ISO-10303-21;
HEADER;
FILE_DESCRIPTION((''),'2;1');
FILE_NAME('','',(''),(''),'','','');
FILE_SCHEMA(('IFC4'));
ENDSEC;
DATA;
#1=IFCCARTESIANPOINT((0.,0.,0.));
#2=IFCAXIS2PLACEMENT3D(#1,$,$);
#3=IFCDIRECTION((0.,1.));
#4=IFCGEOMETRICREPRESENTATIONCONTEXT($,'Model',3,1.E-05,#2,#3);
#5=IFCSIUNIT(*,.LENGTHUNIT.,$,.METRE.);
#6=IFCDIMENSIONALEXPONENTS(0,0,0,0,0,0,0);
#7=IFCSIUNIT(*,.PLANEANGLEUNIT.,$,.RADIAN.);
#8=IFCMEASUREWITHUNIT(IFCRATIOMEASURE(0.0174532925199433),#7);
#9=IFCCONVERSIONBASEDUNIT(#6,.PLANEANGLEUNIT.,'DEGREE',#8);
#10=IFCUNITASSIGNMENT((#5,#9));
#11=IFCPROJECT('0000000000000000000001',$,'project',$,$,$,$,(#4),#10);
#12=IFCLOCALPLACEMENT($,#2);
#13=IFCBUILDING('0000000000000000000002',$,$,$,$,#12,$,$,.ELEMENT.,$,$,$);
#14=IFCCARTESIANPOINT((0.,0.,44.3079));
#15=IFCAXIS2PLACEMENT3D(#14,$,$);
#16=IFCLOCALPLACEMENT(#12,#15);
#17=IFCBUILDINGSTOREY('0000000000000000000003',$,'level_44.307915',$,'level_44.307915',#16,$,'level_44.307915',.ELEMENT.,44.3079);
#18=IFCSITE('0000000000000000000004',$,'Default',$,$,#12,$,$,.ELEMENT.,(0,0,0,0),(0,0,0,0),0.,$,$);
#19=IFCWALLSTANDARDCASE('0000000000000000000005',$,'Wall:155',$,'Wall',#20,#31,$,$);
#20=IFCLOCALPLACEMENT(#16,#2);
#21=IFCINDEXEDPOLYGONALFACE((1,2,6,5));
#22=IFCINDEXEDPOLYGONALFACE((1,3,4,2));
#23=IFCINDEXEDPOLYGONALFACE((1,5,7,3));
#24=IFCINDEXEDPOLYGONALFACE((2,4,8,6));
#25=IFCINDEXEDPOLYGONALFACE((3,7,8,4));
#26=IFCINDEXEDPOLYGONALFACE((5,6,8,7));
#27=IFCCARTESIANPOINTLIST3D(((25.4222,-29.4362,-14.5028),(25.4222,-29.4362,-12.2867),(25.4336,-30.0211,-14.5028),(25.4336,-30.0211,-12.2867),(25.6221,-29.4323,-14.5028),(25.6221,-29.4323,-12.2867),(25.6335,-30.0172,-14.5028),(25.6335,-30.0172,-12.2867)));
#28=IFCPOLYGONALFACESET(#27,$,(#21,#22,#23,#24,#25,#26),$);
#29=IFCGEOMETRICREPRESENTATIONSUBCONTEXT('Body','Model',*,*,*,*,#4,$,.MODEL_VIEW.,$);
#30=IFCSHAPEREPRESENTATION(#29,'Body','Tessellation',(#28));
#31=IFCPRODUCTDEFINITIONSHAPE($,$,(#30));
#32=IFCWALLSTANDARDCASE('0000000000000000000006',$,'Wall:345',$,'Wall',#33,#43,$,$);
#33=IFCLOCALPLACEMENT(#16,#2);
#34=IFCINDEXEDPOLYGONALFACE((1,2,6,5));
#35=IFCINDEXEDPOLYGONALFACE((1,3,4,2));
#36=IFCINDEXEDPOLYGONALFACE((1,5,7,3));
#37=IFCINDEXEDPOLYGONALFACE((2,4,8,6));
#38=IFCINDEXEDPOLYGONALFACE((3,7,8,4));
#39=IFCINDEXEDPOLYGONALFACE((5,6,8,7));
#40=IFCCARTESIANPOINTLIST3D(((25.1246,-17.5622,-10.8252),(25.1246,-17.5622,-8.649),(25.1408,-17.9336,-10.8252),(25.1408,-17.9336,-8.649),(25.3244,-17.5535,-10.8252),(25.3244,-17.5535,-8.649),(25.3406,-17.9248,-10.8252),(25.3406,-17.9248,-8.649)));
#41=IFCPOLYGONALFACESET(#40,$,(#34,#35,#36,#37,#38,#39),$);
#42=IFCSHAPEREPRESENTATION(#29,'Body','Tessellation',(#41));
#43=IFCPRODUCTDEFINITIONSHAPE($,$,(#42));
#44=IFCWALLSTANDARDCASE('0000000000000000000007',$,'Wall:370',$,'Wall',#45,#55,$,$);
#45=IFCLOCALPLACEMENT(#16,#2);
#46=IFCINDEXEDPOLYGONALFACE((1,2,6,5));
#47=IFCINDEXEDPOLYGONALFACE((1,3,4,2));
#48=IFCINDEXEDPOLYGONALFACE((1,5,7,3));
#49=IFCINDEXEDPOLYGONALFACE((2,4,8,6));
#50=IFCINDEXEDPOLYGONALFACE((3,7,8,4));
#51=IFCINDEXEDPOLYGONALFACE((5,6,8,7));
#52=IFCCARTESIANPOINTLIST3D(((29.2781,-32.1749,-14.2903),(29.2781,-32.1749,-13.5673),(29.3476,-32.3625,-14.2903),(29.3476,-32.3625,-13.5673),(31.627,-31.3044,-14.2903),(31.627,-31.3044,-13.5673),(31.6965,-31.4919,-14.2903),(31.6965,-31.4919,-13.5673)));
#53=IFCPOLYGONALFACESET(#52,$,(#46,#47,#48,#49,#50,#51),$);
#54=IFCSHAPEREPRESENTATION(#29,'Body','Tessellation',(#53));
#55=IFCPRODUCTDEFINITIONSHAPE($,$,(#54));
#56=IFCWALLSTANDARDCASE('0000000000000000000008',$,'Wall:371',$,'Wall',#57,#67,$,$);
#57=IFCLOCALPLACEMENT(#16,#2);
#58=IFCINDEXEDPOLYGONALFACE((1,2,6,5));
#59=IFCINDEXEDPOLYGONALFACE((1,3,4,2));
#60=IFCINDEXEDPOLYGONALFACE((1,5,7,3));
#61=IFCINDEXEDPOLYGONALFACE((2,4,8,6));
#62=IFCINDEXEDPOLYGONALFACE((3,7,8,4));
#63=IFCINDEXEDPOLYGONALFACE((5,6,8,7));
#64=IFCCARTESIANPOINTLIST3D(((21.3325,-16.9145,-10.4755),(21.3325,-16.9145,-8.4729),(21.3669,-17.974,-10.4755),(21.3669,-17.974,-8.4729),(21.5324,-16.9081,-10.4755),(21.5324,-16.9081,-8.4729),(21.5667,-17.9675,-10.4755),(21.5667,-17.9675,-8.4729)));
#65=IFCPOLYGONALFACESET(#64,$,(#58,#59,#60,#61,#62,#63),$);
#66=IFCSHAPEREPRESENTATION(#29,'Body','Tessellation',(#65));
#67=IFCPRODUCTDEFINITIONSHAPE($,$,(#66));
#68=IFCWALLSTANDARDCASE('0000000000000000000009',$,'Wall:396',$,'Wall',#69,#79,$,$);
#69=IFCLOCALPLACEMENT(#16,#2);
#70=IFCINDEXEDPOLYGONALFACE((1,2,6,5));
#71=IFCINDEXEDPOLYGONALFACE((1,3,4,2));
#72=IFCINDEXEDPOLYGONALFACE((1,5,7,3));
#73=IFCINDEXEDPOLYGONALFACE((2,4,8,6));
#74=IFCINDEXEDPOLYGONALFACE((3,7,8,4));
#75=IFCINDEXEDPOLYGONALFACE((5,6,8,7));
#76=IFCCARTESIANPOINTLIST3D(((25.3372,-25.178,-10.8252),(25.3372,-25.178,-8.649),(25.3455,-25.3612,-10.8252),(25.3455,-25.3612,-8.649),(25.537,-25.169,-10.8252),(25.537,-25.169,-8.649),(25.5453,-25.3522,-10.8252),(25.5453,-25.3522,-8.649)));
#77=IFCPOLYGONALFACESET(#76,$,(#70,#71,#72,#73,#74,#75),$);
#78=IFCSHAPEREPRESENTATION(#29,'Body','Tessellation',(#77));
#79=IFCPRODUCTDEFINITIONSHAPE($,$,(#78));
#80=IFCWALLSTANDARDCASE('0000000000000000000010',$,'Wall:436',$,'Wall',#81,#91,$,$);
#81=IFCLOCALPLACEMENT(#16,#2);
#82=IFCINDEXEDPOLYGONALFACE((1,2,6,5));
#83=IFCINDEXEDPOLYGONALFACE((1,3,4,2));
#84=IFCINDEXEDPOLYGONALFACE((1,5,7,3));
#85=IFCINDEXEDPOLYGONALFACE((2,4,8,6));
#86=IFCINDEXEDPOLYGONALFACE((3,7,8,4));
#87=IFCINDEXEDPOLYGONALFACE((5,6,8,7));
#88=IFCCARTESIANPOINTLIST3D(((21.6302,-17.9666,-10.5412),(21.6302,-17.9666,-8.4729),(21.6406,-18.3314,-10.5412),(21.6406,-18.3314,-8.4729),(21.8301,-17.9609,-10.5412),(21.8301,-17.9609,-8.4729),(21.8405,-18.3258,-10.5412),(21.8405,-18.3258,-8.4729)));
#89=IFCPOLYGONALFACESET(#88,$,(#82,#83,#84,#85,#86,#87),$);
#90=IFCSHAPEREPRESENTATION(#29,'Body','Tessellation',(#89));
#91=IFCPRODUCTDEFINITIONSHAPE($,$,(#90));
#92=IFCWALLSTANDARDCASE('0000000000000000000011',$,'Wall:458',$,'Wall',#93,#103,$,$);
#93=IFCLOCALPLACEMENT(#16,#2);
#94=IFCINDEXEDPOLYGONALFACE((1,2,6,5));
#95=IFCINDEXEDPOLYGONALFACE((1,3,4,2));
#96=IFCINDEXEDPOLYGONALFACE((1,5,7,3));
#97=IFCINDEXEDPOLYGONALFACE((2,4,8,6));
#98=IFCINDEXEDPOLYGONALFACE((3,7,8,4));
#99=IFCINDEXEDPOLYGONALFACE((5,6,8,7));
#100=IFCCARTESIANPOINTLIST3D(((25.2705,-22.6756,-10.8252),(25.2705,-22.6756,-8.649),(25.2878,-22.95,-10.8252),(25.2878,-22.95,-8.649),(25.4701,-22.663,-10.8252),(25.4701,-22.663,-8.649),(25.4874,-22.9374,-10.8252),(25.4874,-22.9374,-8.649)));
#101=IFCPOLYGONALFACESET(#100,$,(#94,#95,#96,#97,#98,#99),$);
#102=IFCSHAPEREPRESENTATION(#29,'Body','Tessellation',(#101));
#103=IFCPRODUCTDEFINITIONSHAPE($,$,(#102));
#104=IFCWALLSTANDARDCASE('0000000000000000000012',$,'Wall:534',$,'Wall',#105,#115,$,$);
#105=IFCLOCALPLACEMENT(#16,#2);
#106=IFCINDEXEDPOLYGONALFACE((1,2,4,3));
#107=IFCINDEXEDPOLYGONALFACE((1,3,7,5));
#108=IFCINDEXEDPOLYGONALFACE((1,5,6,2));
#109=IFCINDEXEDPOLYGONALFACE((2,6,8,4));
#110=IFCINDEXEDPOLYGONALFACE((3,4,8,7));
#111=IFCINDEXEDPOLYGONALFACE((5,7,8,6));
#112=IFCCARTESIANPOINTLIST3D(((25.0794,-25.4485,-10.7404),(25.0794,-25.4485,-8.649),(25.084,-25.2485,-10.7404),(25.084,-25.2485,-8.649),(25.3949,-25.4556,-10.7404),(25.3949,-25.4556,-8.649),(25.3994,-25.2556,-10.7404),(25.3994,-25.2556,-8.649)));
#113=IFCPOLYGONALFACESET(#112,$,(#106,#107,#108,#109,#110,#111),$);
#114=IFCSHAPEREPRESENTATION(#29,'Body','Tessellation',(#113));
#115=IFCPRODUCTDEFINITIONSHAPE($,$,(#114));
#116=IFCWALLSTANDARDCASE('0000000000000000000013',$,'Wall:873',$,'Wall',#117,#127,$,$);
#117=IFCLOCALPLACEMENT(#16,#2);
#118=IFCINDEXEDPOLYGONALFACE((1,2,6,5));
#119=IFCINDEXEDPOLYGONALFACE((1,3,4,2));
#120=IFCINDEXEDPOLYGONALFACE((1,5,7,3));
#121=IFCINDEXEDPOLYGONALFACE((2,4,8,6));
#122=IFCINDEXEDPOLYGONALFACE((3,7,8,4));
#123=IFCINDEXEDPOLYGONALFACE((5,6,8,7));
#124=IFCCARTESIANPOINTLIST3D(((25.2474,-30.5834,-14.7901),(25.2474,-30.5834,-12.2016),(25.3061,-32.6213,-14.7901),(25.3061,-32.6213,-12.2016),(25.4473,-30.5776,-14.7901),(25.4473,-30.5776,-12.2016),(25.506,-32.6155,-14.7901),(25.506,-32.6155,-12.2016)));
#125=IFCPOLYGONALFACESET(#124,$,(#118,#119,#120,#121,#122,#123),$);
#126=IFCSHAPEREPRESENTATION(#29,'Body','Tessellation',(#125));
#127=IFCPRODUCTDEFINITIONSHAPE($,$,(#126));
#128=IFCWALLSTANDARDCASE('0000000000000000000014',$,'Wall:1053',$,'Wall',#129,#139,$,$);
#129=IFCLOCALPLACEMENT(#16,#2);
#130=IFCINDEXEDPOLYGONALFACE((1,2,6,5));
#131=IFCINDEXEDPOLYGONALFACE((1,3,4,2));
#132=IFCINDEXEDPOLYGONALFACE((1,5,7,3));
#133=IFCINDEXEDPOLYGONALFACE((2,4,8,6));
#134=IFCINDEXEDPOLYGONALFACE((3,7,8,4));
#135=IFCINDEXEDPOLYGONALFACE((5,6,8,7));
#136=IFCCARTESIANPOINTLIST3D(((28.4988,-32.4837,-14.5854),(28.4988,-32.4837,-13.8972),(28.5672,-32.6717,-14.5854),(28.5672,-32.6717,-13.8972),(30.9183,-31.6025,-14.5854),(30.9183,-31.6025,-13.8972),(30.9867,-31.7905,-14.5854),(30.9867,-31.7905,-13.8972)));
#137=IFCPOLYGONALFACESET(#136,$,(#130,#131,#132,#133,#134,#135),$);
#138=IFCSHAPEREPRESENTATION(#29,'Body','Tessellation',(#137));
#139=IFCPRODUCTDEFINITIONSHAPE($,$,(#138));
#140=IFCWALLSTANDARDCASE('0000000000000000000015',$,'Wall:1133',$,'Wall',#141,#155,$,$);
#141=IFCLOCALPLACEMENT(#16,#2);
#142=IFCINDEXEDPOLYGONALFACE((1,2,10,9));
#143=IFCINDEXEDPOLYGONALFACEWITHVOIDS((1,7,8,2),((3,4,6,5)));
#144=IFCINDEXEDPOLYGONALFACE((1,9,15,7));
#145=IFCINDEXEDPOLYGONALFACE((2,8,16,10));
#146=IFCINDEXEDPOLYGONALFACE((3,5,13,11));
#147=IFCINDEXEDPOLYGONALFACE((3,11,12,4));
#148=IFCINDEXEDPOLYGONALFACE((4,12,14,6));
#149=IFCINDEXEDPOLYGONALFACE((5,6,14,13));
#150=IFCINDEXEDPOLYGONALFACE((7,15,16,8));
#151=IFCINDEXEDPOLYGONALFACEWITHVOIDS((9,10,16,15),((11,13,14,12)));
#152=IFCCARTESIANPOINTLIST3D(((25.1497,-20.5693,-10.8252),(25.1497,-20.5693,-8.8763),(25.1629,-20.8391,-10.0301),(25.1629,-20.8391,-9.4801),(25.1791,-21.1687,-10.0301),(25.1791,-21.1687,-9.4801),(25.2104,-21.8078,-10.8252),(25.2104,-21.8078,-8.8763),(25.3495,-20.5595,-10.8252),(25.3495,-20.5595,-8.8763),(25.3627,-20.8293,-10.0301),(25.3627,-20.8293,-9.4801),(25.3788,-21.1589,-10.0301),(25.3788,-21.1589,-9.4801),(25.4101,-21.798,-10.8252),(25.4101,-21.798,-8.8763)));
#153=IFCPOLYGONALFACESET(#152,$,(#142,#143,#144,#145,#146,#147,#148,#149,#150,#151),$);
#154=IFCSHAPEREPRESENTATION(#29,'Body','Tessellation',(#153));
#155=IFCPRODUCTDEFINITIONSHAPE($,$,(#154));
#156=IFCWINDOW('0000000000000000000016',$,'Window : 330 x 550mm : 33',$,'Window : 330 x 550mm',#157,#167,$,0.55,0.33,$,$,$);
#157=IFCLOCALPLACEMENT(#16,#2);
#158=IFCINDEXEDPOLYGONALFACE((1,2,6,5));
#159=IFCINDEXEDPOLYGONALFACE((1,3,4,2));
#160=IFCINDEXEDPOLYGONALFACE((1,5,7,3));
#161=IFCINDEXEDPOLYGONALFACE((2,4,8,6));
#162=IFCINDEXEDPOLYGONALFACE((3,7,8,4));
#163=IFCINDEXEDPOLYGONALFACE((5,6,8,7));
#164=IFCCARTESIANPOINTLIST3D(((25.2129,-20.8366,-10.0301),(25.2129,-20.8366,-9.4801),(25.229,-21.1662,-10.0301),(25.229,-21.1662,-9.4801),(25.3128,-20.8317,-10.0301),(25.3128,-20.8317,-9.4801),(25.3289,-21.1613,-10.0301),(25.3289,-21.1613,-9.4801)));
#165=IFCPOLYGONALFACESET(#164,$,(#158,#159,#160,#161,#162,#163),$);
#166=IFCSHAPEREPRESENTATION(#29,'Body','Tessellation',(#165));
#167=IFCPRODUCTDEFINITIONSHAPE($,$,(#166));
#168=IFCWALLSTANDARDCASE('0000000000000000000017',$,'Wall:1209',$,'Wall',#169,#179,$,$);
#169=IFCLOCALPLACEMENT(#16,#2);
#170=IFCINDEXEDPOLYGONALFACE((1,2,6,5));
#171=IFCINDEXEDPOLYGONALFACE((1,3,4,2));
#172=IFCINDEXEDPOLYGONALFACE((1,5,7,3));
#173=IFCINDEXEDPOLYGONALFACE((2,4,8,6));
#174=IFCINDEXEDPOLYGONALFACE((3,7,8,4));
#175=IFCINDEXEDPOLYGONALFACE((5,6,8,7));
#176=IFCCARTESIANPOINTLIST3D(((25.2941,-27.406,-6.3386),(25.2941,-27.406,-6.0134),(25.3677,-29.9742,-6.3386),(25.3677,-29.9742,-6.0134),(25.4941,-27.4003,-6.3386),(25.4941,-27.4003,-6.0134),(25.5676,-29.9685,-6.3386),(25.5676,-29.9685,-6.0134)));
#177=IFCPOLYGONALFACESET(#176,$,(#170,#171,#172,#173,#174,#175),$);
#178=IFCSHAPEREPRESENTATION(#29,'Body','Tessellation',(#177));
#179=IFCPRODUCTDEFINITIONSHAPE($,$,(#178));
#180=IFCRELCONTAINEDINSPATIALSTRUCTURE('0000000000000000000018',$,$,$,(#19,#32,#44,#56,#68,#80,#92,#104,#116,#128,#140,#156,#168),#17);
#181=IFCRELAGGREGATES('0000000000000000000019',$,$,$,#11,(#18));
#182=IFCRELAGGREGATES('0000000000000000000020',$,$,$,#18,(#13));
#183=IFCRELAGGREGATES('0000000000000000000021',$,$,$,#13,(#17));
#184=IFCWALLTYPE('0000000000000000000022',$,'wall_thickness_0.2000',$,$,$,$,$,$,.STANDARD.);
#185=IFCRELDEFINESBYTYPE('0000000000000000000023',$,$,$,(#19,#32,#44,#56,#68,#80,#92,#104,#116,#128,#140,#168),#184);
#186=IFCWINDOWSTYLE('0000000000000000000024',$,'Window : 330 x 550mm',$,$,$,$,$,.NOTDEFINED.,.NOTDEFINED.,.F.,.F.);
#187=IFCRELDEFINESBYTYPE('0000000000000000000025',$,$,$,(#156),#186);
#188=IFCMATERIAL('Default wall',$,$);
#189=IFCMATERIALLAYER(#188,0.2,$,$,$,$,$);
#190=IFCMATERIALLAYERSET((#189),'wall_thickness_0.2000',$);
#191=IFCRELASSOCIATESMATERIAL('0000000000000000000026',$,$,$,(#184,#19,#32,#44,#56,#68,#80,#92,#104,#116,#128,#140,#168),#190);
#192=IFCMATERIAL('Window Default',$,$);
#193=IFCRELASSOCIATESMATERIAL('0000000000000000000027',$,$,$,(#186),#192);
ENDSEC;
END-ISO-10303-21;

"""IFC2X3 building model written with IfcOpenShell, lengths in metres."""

from ifc_helpers import new_model, entity, si_unit, converted_unit, direction, frame, frame_2d, origin, origin_2d_with_axis, place, context, subcontext, project, spatial, polyline, rectangle, outline, extrude, source, transform, mapped, material, layer, layer_set, layer_usage, type_object, type_shapes, element, fill, save


model = new_model("IFC2X3")

# Units and contexts
model_context = context("Model", 3, precision=1e-05, world=origin(), true_north=direction((0.0, 1.0)))
body_context = subcontext(model_context, "Body", "Model", "MODEL_VIEW")
ifc_project = project(units=[si_unit("LENGTHUNIT", "METRE"), converted_unit("PLANEANGLEUNIT", "DEGREE", entity("IfcRatioMeasure", 0.0174532925199433), si_unit("PLANEANGLEUNIT", "RADIAN"), dimensions=[0, 0, 0, 0, 0, 0, 0])], contexts=[model_context])

# Site, building, storey
placement_1 = place(None, origin())
site = spatial("IfcSite", under=ifc_project, at=placement_1, Name="Default", CompositionType="ELEMENT", RefLatitude=(0, 0, 0, 0), RefLongitude=(0, 0, 0, 0), RefElevation=0.0)
building = spatial("IfcBuilding", under=site, at=placement_1, CompositionType="ELEMENT")
storey_placement = place(placement_1, frame((0.0, 0.0, 44.3079)))
storey = spatial("IfcBuildingStorey", under=building, at=storey_placement, Name="level_44.307915", ObjectType="level_44.307915", LongName="level_44.307915", CompositionType="ELEMENT", Elevation=44.3079)

# Walls
ifc_material_1 = material(Name="Default wall")
ifc_layer = layer(ifc_material_1, 0.2)
ifc_layer_set = layer_set([ifc_layer], Name="wall_thickness_0.2000")
ifc_layer_usage = layer_usage(ifc_layer_set, "AXIS2", "POSITIVE", -0.1)
wall_type = type_object("IfcWallType", Name="wall_thickness_0.2000", PredefinedType="STANDARD", material=ifc_layer_set)
placement_2 = place(placement_1, frame((0.0, 0.0, 29.8051)))
wall_1_placement = place(placement_2, frame((25.5335, -30.0191, 0.0), z_axis=(0.0, 0.0, 1.0), x_axis=(-0.019491, 0.99981, 0.0)))
element("IfcWallStandardCase", 1, at=wall_1_placement, inside=storey, type_object=wall_type, material=ifc_layer_usage, Name="Wall:155", ObjectType="Wall", context=body_context, shape_type="SweptSolid", body=[
    extrude(outline(polyline([(0.585, -0.1), (0.585, 0.1), (0.0, 0.1), (0.0, -0.1), (0.585, -0.1)])), origin(), (0.0, 0.0, 1.0), 2.2162),
])
placement_3 = place(placement_1, frame((0.0, 0.0, 33.4827)))
wall_2_placement = place(placement_3, frame((25.2245, -17.5578, 0.0), z_axis=(0.0, 0.0, 1.0), x_axis=(0.04375, -0.999043, 0.0)))
element("IfcWallStandardCase", 2, at=wall_2_placement, inside=storey, type_object=wall_type, material=ifc_layer_usage, Name="Wall:345", ObjectType="Wall", context=body_context, shape_type="SweptSolid", body=[
    extrude(outline(polyline([(0.3717, -0.1), (0.3717, 0.1), (0.0, 0.1), (0.0, -0.1), (0.3717, -0.1)])), origin(), (0.0, 0.0, 1.0), 2.1761),
])
placement_4 = place(placement_1, frame((0.0, 0.0, 30.0176)))
wall_3_placement = place(placement_4, frame((29.3128, -32.2687, 0.0), z_axis=(0.0, 0.0, 1.0), x_axis=(0.937674, 0.347517, 0.0)))
element("IfcWallStandardCase", 3, at=wall_3_placement, inside=storey, type_object=wall_type, material=ifc_layer_usage, Name="Wall:370", ObjectType="Wall", context=body_context, shape_type="SweptSolid", body=[
    extrude(outline(polyline([(2.505, -0.1), (2.505, 0.1), (0.0, 0.1), (0.0, -0.1), (2.505, -0.1)])), origin(), (0.0, 0.0, 1.0), 0.723),
])
placement_5 = place(placement_1, frame((0.0, 0.0, 33.8324)))
wall_4_placement = place(placement_5, frame((21.4668, -17.9707, 0.0), z_axis=(0.0, 0.0, 1.0), x_axis=(-0.03243, 0.999474, 0.0)))
element("IfcWallStandardCase", 4, at=wall_4_placement, inside=storey, type_object=wall_type, material=ifc_layer_usage, Name="Wall:371", ObjectType="Wall", context=body_context, shape_type="SweptSolid", body=[
    extrude(outline(polyline([(1.06, -0.1), (1.06, 0.1), (0.0, 0.1), (0.0, -0.1), (1.06, -0.1)])), origin(), (0.0, 0.0, 1.0), 2.0025),
])
placement_6 = place(placement_1, frame((0.0, 0.0, 33.4827)))
wall_5_placement = place(placement_6, frame((25.4454, -25.3567, 0.0), z_axis=(0.0, 0.0, 1.0), x_axis=(-0.04528, 0.998974, 0.0)))
element("IfcWallStandardCase", 5, at=wall_5_placement, inside=storey, type_object=wall_type, material=ifc_layer_usage, Name="Wall:396", ObjectType="Wall", context=body_context, shape_type="SweptSolid", body=[
    extrude(outline(polyline([(0.1834, -0.1), (0.1834, 0.1), (0.0, 0.1), (0.0, -0.1), (0.1834, -0.1)])), origin(), (0.0, 0.0, 1.0), 2.1761),
])
placement_7 = place(placement_1, frame((0.0, 0.0, 33.7667)))
wall_6_placement = place(placement_7, frame((21.7302, -17.9637, 0.0), z_axis=(0.0, 0.0, 1.0), x_axis=(0.028328, -0.999599, 0.0)))
element("IfcWallStandardCase", 6, at=wall_6_placement, inside=storey, type_object=wall_type, material=ifc_layer_usage, Name="Wall:436", ObjectType="Wall", context=body_context, shape_type="SweptSolid", body=[
    extrude(outline(polyline([(0.365, -0.1), (0.365, 0.1), (0.0, 0.1), (0.0, -0.1), (0.365, -0.1)])), origin(), (0.0, 0.0, 1.0), 2.0683),
])
placement_8 = place(placement_1, frame((0.0, 0.0, 33.4827)))
wall_7_placement = place(placement_8, frame((25.3703, -22.6693, 0.0), z_axis=(0.0, 0.0, 1.0), x_axis=(0.062929, -0.998018, 0.0)))
element("IfcWallStandardCase", 7, at=wall_7_placement, inside=storey, type_object=wall_type, material=ifc_layer_usage, Name="Wall:458", ObjectType="Wall", context=body_context, shape_type="SweptSolid", body=[
    extrude(outline(polyline([(0.275, -0.1), (0.275, 0.1), (0.0, 0.1), (0.0, -0.1), (0.275, -0.1)])), origin(), (0.0, 0.0, 1.0), 2.1761),
])
placement_9 = place(placement_1, frame((0.0, 0.0, 33.5675)))
wall_8_placement = place(placement_9, frame((25.3972, -25.3556, 0.0), z_axis=(0.0, 0.0, 1.0), x_axis=(-0.999744, 0.022626, 0.0)))
element("IfcWallStandardCase", 8, at=wall_8_placement, inside=storey, type_object=wall_type, material=ifc_layer_usage, Name="Wall:534", ObjectType="Wall", context=body_context, shape_type="SweptSolid", body=[
    extrude(outline(polyline([(0.3155, -0.1), (0.3155, 0.1), (0.0, 0.1), (0.0, -0.1), (0.3155, -0.1)])), origin(), (0.0, 0.0, 1.0), 2.0914),
])
placement_10 = place(placement_1, frame((0.0, 0.0, 29.5178)))
wall_9_placement = place(placement_10, frame((25.3474, -30.5805, 0.0), z_axis=(0.0, 0.0, 1.0), x_axis=(0.028788, -0.999586, 0.0)))
element("IfcWallStandardCase", 9, at=wall_9_placement, inside=storey, type_object=wall_type, material=ifc_layer_usage, Name="Wall:873", ObjectType="Wall", context=body_context, shape_type="SweptSolid", body=[
    extrude(outline(polyline([(2.0387, -0.1), (2.0387, 0.1), (0.0, 0.1), (0.0, -0.1), (2.0387, -0.1)])), origin(), (0.0, 0.0, 1.0), 2.5885),
])
placement_11 = place(placement_1, frame((0.0, 0.0, 29.7225)))
wall_10_placement = place(placement_11, frame((28.533, -32.5777, 0.0), z_axis=(0.0, 0.0, 1.0), x_axis=(0.93962, 0.34222, 0.0)))
element("IfcWallStandardCase", 10, at=wall_10_placement, inside=storey, type_object=wall_type, material=ifc_layer_usage, Name="Wall:1053", ObjectType="Wall", context=body_context, shape_type="SweptSolid", body=[
    extrude(outline(polyline([(2.575, -0.1), (2.575, 0.1), (0.0, 0.1), (0.0, -0.1), (2.575, -0.1)])), origin(), (0.0, 0.0, 1.0), 0.6882),
])

# Wall, opening, window
placement_12 = place(placement_1, frame((0.0, 0.0, 33.4827)))
wall_11_placement = place(placement_12, frame((25.3102, -21.8029, 0.0), z_axis=(0.0, 0.0, 1.0), x_axis=(-0.048908, 0.998803, 0.0)))
wall_11 = element("IfcWallStandardCase", 11, at=wall_11_placement, inside=storey, type_object=wall_type, material=ifc_layer_usage, Name="Wall:1133", ObjectType="Wall", context=body_context, shape_type="SweptSolid", body=[
    extrude(outline(polyline([(1.24, -0.1), (1.24, 0.1), (0.0, 0.1), (0.0, -0.1), (1.24, -0.1)])), origin(), (0.0, 0.0, 1.0), 1.9489),
])
opening_1_placement = place(wall_11_placement, frame((0.6399, -0.1, 0.7951)))
opening_1 = element("IfcOpeningElement", 12, at=opening_1_placement, cuts=wall_11, ObjectType="Opening", context=body_context, shape_type="SweptSolid", body=[
    extrude(rectangle(XDim=0.33, YDim=0.55, at=frame_2d((0.275, 0.165), x_axis=(0.0, 1.0))), frame((0.0, 0.0, 0.0), z_axis=(0.0, 1.0, 0.0), x_axis=(0.0, 0.0, 1.0)), (0.0, 0.0, 1.0), 0.2),
])
ifc_material_2 = material(Name="Window Default")
window_style_1 = type_object("IfcWindowStyle", Name="Window : 330 x 550mm", ConstructionType="NOTDEFINED", OperationType="NOTDEFINED", ParameterTakesPrecedence=False, Sizeable=False, material=ifc_material_2)
shared_shape_1 = source(origin(), body_context, "Body", "SweptSolid", [
    extrude(rectangle(XDim=0.1, YDim=0.33, at=origin_2d_with_axis()), frame((0.165, 0.1, 0.0), z_axis=(0.0, 0.0, 1.0), x_axis=(0.0, 1.0, 0.0)), (0.0, 0.0, 1.0), 0.55),
])
type_shapes(window_style_1, [shared_shape_1])
window_1_placement = place(opening_1_placement, origin())
window_1 = element("IfcWindow", 13, at=window_1_placement, inside=storey, type_object=window_style_1, Name="Window : 330 x 550mm : 33", ObjectType="Window : 330 x 550mm", OverallHeight=0.55, OverallWidth=0.33, context=body_context, shape_type="MappedRepresentation", body=[
    mapped(shared_shape_1, transform((0.0, 0.0, 0.0), scale=1.0)),
])
fill(opening_1, window_1)

# Wall
placement_13 = place(placement_1, frame((0.0, 0.0, 37.9693)))
wall_12_placement = place(placement_13, frame((25.3941, -27.4031, 0.0), z_axis=(0.0, 0.0, 1.0), x_axis=(0.028621, -0.99959, 0.0)))
element("IfcWallStandardCase", 14, at=wall_12_placement, inside=storey, type_object=wall_type, material=ifc_layer_usage, Name="Wall:1209", ObjectType="Wall", context=body_context, shape_type="SweptSolid", body=[
    extrude(outline(polyline([(2.5693, -0.1), (2.5693, 0.1), (0.0, 0.1), (0.0, -0.1), (2.5693, -0.1)])), origin(), (0.0, 0.0, 1.0), 0.3252),
])

save(model, "model.ifc")
